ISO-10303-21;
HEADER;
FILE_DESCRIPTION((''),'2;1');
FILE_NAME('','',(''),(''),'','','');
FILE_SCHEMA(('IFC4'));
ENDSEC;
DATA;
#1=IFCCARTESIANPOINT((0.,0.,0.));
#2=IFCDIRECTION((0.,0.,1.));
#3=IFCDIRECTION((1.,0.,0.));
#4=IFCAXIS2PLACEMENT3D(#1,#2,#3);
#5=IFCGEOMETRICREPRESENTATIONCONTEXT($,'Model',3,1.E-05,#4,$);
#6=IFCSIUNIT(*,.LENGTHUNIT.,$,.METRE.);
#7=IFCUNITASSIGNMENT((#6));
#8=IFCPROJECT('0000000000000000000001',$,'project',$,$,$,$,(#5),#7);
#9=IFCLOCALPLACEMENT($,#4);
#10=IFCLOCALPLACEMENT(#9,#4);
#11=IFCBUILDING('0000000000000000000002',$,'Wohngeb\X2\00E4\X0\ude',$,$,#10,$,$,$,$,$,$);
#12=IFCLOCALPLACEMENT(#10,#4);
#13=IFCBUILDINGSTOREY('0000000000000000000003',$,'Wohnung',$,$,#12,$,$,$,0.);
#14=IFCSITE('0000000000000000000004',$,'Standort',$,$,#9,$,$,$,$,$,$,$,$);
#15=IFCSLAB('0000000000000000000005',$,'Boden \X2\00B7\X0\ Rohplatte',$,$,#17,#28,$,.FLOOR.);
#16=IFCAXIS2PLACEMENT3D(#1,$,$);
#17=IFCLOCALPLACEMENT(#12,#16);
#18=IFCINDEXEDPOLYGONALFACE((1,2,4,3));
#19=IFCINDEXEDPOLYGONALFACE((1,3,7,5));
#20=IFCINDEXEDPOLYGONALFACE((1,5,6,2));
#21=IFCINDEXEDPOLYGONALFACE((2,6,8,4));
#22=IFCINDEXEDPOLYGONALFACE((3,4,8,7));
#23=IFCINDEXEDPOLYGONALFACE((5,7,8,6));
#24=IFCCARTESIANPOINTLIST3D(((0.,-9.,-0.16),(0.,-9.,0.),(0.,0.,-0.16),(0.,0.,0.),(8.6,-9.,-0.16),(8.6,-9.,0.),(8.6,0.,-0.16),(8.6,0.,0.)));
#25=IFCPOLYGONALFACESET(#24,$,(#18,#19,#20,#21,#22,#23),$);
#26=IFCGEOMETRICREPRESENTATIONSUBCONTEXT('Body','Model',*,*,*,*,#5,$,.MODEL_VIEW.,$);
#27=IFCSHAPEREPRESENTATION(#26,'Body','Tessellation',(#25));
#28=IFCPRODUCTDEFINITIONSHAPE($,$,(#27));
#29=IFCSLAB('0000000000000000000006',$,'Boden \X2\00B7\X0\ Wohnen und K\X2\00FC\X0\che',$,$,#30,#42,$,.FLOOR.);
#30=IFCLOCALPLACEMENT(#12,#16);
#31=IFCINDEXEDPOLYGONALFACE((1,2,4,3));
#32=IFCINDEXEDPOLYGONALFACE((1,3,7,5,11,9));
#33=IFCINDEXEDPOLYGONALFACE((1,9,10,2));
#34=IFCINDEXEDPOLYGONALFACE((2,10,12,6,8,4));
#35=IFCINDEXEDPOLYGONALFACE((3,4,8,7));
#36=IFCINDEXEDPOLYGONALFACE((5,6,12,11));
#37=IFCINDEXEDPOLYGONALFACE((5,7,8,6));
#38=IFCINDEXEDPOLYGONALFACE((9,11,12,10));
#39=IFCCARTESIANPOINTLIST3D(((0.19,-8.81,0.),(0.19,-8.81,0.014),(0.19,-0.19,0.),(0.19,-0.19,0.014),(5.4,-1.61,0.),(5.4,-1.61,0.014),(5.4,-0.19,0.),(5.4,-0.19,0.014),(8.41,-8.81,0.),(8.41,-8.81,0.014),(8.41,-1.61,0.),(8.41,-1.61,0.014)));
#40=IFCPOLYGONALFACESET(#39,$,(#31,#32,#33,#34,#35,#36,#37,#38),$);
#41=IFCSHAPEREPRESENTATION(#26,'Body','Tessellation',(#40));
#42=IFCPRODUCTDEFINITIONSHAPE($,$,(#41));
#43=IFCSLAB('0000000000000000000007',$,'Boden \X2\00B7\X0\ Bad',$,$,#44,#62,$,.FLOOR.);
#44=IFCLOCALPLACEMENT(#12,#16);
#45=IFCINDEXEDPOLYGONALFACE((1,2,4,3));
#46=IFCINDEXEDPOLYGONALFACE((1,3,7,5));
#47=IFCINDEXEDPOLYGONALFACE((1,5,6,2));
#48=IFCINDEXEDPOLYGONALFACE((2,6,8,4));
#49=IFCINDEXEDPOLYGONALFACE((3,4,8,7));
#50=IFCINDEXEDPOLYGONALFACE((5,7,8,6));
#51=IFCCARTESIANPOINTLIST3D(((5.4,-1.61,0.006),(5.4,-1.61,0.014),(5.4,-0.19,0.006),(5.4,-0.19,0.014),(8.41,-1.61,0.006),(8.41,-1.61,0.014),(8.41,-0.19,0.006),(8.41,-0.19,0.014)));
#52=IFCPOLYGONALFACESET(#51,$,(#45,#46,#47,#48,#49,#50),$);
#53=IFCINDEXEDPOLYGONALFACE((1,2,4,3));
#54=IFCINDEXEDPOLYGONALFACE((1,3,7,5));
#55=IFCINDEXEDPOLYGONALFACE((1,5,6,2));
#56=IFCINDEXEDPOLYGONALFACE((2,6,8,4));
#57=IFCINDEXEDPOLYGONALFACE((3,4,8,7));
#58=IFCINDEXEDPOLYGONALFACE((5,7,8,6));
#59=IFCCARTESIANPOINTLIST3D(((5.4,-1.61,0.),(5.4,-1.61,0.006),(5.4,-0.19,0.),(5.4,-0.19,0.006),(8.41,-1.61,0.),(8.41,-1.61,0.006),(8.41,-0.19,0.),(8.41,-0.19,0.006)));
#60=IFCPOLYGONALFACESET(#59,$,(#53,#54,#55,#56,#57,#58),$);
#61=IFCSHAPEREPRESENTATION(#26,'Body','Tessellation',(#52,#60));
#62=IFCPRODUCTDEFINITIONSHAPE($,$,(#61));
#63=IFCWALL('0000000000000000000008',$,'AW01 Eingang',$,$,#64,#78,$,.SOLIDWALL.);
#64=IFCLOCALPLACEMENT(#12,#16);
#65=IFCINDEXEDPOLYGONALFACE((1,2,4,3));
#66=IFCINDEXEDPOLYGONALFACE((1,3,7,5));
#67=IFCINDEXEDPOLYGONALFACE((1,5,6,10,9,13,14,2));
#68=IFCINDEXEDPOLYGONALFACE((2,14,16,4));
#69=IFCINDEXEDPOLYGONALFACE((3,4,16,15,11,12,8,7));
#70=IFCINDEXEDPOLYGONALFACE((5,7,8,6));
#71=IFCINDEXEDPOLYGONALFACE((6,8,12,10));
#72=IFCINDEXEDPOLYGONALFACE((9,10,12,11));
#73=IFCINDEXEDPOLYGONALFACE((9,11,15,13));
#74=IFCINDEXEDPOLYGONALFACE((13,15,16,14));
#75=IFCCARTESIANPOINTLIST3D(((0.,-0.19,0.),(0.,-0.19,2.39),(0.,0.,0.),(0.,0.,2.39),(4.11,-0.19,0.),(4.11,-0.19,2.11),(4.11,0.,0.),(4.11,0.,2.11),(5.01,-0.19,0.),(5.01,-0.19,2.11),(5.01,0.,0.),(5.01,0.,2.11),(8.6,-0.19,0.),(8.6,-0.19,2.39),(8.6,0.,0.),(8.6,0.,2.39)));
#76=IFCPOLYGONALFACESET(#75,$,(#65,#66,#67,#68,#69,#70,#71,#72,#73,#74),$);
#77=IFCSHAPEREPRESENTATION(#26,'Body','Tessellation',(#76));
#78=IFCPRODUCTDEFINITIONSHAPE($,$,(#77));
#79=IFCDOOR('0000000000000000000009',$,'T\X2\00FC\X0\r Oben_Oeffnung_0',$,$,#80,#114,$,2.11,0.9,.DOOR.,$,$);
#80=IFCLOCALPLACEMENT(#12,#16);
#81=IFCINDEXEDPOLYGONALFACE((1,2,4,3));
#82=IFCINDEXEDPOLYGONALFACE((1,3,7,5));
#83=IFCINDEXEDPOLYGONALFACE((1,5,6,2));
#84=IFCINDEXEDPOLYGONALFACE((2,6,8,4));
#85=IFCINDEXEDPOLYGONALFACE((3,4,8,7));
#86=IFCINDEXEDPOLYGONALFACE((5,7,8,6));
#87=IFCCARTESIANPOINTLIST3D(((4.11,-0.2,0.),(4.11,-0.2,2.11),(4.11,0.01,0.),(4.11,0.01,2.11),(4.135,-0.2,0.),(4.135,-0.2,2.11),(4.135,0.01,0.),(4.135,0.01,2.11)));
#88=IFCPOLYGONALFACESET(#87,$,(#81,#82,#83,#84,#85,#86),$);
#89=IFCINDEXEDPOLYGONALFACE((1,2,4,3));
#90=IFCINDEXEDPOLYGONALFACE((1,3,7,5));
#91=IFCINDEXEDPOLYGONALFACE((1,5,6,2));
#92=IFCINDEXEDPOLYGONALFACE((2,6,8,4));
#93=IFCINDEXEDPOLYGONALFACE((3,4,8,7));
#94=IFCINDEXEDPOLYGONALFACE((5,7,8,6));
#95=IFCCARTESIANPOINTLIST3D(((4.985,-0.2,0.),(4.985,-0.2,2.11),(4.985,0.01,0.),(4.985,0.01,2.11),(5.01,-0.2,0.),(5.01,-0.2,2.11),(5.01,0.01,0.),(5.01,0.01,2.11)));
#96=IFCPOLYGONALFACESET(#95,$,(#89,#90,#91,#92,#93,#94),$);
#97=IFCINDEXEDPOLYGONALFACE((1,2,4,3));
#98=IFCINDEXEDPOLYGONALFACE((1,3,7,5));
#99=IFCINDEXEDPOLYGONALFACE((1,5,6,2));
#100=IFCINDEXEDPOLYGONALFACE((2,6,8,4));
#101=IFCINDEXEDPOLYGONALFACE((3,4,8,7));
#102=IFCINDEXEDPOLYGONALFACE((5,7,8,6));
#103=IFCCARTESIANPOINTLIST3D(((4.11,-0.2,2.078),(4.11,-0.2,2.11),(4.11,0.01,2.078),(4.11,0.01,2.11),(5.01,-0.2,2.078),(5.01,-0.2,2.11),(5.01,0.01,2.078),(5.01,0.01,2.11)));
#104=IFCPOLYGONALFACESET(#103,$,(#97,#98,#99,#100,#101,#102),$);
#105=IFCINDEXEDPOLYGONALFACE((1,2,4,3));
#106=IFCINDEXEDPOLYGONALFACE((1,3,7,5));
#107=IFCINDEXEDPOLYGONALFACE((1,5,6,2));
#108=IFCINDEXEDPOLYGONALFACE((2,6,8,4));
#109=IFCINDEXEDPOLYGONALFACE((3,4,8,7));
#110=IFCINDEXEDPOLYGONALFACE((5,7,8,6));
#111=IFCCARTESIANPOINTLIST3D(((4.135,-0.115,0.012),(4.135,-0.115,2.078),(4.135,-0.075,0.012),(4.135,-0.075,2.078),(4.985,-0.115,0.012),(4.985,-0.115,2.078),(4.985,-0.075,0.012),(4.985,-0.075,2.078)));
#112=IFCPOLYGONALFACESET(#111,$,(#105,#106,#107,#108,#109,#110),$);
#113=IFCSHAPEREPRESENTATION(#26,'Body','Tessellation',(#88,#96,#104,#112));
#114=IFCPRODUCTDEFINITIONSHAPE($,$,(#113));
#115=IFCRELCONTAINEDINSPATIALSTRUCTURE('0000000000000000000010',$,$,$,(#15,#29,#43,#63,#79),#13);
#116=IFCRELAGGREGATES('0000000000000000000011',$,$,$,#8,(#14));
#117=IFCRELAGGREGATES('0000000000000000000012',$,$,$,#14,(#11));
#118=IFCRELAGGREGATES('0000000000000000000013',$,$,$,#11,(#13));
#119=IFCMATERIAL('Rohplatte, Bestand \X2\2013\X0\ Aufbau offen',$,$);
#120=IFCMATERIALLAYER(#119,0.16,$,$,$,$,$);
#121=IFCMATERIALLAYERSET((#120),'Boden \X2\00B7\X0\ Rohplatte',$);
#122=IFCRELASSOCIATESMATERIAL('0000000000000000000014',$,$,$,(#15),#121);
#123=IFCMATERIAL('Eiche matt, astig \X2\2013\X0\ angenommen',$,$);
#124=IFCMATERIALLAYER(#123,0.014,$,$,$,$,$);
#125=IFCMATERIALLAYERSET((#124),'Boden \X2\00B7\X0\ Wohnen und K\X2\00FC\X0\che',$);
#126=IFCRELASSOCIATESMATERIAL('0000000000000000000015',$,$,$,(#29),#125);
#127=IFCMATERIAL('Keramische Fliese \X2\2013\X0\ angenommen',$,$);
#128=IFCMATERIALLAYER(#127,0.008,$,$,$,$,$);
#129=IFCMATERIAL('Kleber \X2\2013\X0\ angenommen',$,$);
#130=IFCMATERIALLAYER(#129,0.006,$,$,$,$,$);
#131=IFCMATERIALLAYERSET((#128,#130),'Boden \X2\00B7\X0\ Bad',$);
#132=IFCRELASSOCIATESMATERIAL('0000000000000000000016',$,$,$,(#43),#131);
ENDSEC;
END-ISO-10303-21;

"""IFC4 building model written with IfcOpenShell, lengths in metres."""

from ifc_helpers import new_model, si_unit, frame, origin, origin_with_axes, place, context, subcontext, project, spatial, polyline, outline, extrude, material, layer, layer_set, element, fill, save


model = new_model("IFC4")

# Units and contexts
model_context = context("Model", 3, precision=1e-05, world=origin_with_axes())
body_context = subcontext(model_context, "Body", "Model", "MODEL_VIEW")
ifc_project = project(units=[si_unit("LENGTHUNIT", "METRE")], contexts=[model_context])

# Site, building, storey
site_placement = place(None, origin_with_axes())
site = spatial("IfcSite", under=ifc_project, at=site_placement, Name="Standort")
building_placement = place(site_placement, origin_with_axes())
building = spatial("IfcBuilding", under=site, at=building_placement, Name="Wohngebäude")
storey_placement = place(building_placement, origin_with_axes())
storey = spatial("IfcBuildingStorey", under=building, at=storey_placement, Name="Wohnung", Elevation=0.0)

# Slabs
ifc_material_1 = material(Name="Rohplatte, Bestand – Aufbau offen")
ifc_layer_1 = layer(ifc_material_1, 0.16)
ifc_layer_set_1 = layer_set([ifc_layer_1], Name="Boden · Rohplatte")
slab_1_placement = place(storey_placement, origin_with_axes())
element("IfcSlab", 1, at=slab_1_placement, inside=storey, material=ifc_layer_set_1, Name="Boden · Rohplatte", PredefinedType="FLOOR", context=body_context, shape_type="SweptSolid", body=[
    extrude(outline(polyline([(0.0, 0.0), (8.6, 0.0), (8.6, -9.0), (0.0, -9.0), (0.0, 0.0)])), frame((0.0, 0.0, -0.16)), (0.0, 0.0, 1.0), 0.16),
])
ifc_material_2 = material(Name="Eiche matt, astig – angenommen")
ifc_layer_2 = layer(ifc_material_2, 0.014)
ifc_layer_set_2 = layer_set([ifc_layer_2], Name="Boden · Wohnen und Küche")
slab_2_placement = place(storey_placement, origin_with_axes())
element("IfcSlab", 2, at=slab_2_placement, inside=storey, material=ifc_layer_set_2, Name="Boden · Wohnen und Küche", PredefinedType="FLOOR", context=body_context, shape_type="SweptSolid", body=[
    extrude(outline(polyline([(0.19, -0.19), (5.4, -0.19), (5.4, -1.61), (8.41, -1.61), (8.41, -8.81), (0.19, -8.81), (0.19, -0.19)])), origin(), (0.0, 0.0, 1.0), 0.014),
])
ifc_material_3 = material(Name="Keramische Fliese – angenommen")
ifc_layer_3 = layer(ifc_material_3, 0.008)
ifc_material_4 = material(Name="Kleber – angenommen")
ifc_layer_4 = layer(ifc_material_4, 0.006)
ifc_layer_set_3 = layer_set([ifc_layer_3, ifc_layer_4], Name="Boden · Bad")
slab_3_placement = place(storey_placement, origin_with_axes())
element("IfcSlab", 3, at=slab_3_placement, inside=storey, material=ifc_layer_set_3, Name="Boden · Bad", PredefinedType="FLOOR", context=body_context, shape_type="SweptSolid", body=[
    extrude(outline(polyline([(5.4, -0.19), (8.41, -0.19), (8.41, -1.61), (5.4, -1.61), (5.4, -0.19)])), frame((0.0, 0.0, 0.006)), (0.0, 0.0, 1.0), 0.008),
    extrude(outline(polyline([(5.4, -0.19), (8.41, -0.19), (8.41, -1.61), (5.4, -1.61), (5.4, -0.19)])), origin(), (0.0, 0.0, 1.0), 0.006),
])

# Wall, opening, door
wall_1_placement = place(storey_placement, origin_with_axes())
wall_1 = element("IfcWall", 4, at=wall_1_placement, inside=storey, Name="AW01 Eingang", PredefinedType="SOLIDWALL", context=body_context, shape_type="SweptSolid", body=[
    extrude(outline(polyline([(0.0, 0.0), (0.0, -0.19), (8.6, -0.19), (8.6, 0.0), (0.0, 0.0)])), origin(), (0.0, 0.0, 1.0), 2.39),
])
opening_1_placement = place(wall_1_placement, frame((4.11, 0.0, 0.0), z_axis=(0.0, 0.0, 1.0), x_axis=(1.0, 0.0, 0.0)))
opening_1 = element("IfcOpeningElement", 5, at=opening_1_placement, cuts=wall_1, PredefinedType="OPENING", context=body_context, shape_type="SweptSolid", body=[
    extrude(outline(polyline([(0.0, 0.005), (0.0, -0.195), (0.9, -0.195), (0.9, 0.005), (0.0, 0.005)])), origin(), (0.0, 0.0, 1.0), 2.11),
])
door_1_placement = place(storey_placement, frame((4.11, 0.0, 0.0), z_axis=(0.0, 0.0, 1.0), x_axis=(1.0, 0.0, 0.0)))
door_1 = element("IfcDoor", 6, at=door_1_placement, inside=storey, Name="Tür Oben_Oeffnung_0", OverallHeight=2.11, OverallWidth=0.9, PredefinedType="DOOR", context=body_context, shape_type="SweptSolid", body=[
    extrude(outline(polyline([(0.0, 0.01), (0.0, -0.2), (0.025, -0.2), (0.025, 0.01), (0.0, 0.01)])), origin(), (0.0, 0.0, 1.0), 2.11),
    extrude(outline(polyline([(0.875, 0.01), (0.875, -0.2), (0.9, -0.2), (0.9, 0.01), (0.875, 0.01)])), origin(), (0.0, 0.0, 1.0), 2.11),
    extrude(outline(polyline([(0.0, 0.01), (0.0, -0.2), (0.9, -0.2), (0.9, 0.01), (0.0, 0.01)])), frame((0.0, 0.0, 2.078)), (0.0, 0.0, 1.0), 0.032),
    extrude(outline(polyline([(0.025, -0.075), (0.025, -0.115), (0.875, -0.115), (0.875, -0.075), (0.025, -0.075)])), frame((0.0, 0.0, 0.012)), (0.0, 0.0, 1.0), 2.066),
])
fill(opening_1, door_1)

save(model, "model.ifc")
